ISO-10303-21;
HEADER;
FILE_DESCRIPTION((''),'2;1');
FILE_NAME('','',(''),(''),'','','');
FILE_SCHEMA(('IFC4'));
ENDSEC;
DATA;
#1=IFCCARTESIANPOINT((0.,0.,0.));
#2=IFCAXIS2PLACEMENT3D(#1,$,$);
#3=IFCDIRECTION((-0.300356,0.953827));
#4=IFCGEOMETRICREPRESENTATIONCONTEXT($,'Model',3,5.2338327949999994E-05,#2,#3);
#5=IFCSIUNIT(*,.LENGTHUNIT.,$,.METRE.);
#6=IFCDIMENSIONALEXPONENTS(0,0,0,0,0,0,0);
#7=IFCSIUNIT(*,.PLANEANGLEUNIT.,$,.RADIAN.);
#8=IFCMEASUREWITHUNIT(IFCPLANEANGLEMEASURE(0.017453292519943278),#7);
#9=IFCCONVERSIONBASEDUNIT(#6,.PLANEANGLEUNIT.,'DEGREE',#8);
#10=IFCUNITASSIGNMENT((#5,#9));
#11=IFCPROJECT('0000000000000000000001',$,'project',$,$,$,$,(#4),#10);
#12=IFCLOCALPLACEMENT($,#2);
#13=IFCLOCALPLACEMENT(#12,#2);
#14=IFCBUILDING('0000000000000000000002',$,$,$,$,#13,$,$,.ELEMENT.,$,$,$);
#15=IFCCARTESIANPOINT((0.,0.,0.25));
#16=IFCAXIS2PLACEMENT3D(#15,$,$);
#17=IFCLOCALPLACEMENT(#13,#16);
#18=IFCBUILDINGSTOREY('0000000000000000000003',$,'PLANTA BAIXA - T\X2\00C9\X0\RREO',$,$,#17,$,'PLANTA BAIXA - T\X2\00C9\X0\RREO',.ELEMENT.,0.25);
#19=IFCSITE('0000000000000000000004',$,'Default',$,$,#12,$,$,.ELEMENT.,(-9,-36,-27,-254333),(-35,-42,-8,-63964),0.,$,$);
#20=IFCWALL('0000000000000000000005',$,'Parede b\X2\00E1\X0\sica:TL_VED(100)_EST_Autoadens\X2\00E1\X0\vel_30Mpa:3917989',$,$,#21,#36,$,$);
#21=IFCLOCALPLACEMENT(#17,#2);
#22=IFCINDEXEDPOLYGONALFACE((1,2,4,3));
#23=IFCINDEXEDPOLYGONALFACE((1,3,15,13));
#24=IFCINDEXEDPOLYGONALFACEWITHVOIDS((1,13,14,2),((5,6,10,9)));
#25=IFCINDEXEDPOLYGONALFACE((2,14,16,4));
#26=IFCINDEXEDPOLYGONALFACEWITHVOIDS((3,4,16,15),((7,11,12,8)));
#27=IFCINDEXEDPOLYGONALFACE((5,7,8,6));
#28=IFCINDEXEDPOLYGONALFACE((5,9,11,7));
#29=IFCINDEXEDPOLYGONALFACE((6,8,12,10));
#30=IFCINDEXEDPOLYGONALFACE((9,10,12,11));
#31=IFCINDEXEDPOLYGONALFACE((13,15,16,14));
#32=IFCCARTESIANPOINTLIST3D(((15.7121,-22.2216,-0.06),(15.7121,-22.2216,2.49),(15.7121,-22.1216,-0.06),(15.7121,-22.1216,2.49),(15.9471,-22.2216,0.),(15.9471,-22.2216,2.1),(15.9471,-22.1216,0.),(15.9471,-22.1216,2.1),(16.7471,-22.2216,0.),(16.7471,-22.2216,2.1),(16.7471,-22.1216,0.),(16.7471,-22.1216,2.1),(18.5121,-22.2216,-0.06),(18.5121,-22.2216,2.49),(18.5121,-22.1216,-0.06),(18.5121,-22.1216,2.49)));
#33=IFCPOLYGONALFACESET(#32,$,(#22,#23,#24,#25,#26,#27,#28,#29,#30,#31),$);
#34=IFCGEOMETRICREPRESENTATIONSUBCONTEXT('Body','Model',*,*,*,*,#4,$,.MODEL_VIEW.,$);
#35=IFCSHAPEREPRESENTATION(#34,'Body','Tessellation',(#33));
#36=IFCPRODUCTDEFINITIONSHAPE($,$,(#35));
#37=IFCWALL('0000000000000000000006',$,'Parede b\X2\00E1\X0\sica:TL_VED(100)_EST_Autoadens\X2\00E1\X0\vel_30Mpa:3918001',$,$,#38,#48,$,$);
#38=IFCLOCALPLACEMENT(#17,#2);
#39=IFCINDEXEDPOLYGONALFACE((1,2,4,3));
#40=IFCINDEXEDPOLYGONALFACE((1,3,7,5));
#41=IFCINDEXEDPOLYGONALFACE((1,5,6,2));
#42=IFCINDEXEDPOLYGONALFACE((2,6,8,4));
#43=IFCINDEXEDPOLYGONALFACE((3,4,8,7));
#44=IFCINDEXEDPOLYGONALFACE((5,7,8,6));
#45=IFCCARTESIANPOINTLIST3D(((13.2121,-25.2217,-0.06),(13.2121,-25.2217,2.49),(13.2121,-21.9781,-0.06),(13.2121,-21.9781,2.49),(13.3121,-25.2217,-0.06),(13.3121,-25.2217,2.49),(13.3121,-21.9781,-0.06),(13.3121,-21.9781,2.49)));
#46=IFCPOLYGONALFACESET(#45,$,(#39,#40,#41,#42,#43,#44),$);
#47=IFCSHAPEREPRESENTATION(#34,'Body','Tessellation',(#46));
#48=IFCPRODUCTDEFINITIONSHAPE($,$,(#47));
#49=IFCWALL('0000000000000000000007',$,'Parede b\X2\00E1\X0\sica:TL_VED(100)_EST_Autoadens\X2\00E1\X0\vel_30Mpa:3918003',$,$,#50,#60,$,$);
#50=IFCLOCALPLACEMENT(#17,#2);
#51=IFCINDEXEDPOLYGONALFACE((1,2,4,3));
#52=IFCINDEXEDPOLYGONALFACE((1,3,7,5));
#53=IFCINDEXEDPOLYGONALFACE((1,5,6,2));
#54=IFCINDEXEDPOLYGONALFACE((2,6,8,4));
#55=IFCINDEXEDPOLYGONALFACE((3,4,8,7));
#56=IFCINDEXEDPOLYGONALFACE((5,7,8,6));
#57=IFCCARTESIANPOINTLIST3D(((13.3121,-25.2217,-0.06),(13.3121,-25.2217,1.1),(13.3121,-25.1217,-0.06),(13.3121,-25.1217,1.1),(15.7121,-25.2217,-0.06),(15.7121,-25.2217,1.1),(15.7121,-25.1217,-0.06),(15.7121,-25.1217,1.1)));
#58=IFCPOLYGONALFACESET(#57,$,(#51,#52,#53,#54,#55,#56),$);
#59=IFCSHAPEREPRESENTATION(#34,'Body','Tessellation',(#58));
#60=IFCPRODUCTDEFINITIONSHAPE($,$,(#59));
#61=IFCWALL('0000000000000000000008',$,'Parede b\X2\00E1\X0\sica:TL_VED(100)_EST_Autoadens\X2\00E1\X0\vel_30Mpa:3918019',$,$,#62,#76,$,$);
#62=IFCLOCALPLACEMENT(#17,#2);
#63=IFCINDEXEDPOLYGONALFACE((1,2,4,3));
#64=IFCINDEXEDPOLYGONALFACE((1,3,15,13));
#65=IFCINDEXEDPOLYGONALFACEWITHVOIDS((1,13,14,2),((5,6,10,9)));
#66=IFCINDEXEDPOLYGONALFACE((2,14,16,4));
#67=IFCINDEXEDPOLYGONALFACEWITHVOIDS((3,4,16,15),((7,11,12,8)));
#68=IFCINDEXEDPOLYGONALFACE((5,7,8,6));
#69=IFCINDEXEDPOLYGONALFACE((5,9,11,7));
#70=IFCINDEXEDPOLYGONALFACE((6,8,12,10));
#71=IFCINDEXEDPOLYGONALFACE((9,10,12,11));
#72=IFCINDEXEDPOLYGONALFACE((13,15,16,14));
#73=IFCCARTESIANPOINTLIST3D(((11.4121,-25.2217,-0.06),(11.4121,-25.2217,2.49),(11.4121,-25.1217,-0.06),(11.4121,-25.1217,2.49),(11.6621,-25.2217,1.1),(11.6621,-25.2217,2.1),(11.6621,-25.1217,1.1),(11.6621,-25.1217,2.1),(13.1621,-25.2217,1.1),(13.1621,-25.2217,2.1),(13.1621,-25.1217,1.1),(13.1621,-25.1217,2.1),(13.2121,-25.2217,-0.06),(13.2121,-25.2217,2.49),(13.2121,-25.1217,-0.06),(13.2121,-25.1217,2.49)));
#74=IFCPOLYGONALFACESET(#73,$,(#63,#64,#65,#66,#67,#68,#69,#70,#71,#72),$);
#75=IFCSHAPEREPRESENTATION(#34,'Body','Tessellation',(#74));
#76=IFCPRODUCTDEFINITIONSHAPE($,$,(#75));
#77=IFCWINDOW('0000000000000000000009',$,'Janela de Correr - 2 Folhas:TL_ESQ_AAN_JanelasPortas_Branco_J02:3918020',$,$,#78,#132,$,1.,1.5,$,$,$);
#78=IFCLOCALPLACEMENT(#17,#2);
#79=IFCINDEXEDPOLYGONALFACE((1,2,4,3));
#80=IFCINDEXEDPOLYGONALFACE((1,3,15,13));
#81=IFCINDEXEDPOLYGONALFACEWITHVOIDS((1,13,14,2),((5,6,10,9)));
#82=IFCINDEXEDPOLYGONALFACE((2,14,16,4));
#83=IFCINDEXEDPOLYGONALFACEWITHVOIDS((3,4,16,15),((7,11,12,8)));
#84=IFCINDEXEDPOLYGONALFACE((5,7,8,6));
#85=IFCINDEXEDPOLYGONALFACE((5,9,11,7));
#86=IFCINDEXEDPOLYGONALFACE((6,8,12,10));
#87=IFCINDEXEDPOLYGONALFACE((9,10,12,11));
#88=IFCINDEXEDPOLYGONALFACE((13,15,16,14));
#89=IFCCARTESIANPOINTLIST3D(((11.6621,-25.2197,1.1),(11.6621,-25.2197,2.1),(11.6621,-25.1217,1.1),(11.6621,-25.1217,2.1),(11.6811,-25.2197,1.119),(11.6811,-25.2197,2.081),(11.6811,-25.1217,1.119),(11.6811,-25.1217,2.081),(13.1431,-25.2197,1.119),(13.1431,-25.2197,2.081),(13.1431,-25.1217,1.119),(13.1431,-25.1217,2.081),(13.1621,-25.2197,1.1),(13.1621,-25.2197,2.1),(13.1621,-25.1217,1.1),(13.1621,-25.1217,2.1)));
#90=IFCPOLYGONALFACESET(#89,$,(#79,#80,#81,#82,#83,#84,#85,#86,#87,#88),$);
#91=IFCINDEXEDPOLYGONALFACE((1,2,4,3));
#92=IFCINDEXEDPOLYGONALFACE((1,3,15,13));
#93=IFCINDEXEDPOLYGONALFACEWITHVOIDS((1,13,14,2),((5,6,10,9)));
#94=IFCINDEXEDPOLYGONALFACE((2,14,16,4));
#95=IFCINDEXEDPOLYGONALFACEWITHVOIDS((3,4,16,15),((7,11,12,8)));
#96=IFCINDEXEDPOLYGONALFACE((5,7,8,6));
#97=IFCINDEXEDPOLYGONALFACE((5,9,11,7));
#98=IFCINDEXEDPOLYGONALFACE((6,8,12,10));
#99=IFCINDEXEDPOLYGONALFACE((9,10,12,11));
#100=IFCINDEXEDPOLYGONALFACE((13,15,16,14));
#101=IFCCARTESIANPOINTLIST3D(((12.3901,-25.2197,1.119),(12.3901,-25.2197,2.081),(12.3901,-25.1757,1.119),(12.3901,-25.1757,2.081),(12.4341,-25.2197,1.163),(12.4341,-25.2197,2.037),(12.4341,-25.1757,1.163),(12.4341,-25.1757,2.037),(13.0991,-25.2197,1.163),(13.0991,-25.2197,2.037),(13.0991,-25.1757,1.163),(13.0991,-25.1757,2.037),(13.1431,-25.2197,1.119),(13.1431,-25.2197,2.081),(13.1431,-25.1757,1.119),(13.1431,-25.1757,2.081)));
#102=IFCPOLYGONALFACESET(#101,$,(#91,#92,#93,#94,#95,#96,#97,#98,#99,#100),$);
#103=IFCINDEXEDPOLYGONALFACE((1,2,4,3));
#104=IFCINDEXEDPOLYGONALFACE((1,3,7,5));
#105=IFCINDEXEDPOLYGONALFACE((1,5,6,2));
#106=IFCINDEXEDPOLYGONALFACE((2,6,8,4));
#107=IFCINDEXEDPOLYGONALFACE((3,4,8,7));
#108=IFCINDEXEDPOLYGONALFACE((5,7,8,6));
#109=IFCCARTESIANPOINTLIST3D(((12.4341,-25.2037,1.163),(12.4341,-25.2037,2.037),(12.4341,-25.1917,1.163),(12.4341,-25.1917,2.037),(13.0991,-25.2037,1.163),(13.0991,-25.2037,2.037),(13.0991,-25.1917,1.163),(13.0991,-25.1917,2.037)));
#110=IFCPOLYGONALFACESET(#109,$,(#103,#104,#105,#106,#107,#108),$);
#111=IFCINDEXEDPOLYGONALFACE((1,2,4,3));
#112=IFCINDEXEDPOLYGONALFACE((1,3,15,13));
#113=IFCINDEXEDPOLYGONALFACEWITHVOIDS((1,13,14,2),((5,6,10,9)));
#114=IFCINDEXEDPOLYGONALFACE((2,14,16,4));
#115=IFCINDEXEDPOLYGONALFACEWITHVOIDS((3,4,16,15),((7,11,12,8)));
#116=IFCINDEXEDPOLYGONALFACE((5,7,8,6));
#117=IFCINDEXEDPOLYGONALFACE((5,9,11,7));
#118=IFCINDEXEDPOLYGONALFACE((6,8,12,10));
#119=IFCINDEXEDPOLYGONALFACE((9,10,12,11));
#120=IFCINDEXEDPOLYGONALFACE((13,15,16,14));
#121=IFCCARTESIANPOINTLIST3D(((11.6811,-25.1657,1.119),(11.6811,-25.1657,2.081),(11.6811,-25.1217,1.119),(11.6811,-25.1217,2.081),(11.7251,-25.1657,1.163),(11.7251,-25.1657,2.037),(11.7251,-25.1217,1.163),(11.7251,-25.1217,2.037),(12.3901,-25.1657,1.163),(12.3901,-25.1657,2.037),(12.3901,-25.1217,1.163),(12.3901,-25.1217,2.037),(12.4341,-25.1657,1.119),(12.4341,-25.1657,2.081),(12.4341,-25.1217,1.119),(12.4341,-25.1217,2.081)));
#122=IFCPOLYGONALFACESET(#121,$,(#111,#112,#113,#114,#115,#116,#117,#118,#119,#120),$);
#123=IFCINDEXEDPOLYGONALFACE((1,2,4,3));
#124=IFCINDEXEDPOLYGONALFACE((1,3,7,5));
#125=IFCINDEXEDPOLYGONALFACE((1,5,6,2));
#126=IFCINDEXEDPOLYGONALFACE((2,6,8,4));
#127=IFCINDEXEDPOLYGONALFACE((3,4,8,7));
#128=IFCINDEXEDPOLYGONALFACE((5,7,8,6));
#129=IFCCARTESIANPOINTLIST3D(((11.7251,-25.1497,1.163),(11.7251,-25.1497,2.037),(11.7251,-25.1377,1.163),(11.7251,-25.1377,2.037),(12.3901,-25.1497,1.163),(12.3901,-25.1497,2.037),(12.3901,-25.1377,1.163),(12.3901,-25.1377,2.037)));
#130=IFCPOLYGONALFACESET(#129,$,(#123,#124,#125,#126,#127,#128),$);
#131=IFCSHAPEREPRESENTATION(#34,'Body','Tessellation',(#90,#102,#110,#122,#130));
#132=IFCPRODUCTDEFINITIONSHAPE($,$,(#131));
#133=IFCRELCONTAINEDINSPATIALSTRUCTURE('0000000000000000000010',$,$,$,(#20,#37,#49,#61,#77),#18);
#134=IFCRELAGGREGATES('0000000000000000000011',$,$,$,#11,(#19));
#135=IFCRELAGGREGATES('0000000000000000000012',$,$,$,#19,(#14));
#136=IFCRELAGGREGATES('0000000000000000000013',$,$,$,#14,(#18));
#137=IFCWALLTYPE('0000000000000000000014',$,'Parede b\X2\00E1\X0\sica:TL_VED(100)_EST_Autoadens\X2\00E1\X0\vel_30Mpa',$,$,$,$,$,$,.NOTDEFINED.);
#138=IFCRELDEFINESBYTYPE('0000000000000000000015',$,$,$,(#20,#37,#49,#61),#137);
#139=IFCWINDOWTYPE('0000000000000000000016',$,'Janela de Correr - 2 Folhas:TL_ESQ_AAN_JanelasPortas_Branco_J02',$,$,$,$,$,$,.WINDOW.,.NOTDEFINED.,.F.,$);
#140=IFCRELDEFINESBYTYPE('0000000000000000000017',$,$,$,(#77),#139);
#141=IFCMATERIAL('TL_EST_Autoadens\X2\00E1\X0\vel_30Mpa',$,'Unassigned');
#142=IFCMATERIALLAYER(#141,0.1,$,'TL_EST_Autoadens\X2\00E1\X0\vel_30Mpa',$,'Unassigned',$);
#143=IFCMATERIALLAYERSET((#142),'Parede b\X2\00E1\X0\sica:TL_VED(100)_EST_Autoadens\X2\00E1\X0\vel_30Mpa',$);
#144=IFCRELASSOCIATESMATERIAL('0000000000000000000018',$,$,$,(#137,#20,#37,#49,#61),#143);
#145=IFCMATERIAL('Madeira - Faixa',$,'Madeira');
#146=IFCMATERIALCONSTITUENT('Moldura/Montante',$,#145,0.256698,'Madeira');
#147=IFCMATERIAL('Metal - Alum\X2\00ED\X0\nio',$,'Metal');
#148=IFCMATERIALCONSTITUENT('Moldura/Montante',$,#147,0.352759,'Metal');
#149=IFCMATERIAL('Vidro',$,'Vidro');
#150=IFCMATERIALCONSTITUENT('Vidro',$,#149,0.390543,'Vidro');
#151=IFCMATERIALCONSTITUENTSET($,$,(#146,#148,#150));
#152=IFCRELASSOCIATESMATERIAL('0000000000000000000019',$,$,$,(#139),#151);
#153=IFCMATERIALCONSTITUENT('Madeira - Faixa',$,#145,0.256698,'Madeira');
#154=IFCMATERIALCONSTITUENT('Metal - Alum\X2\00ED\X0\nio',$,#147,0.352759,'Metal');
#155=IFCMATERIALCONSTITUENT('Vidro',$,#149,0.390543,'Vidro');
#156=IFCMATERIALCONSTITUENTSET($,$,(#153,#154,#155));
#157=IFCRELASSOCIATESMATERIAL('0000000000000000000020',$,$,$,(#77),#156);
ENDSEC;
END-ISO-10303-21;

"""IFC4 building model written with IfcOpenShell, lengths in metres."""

from ifc_helpers import new_model, entity, si_unit, converted_unit, direction, frame, frame_2d, origin, origin_2d_with_axis, place, context, subcontext, project, spatial, polyline, rectangle, outline, extrude, source, transform, mapped, material, layer, layer_set, layer_usage, constituent, constituent_set, type_object, type_shapes, element, fill, save


model = new_model("IFC4")

# Units and contexts
model_context = context("Model", 3, precision=5.2338327949999994e-05, world=origin(), true_north=direction((-0.300356, 0.953827)))
body_context = subcontext(model_context, "Body", "Model", "MODEL_VIEW")
ifc_project = project(units=[si_unit("LENGTHUNIT", "METRE"), converted_unit("PLANEANGLEUNIT", "DEGREE", entity("IfcPlaneAngleMeasure", 0.017453292519943278), si_unit("PLANEANGLEUNIT", "RADIAN"), dimensions=[0, 0, 0, 0, 0, 0, 0])], contexts=[model_context])

# Site, building, storey
site_placement = place(None, origin())
site = spatial("IfcSite", under=ifc_project, at=site_placement, Name="Default", CompositionType="ELEMENT", RefLatitude=(-9, -36, -27, -254333), RefLongitude=(-35, -42, -8, -63964), RefElevation=0.0)
building_placement = place(site_placement, origin())
building = spatial("IfcBuilding", under=site, at=building_placement, CompositionType="ELEMENT")
storey_placement = place(building_placement, frame((0.0, 0.0, 0.25)))
storey = spatial("IfcBuildingStorey", under=building, at=storey_placement, Name="PLANTA BAIXA - TÉRREO", LongName="PLANTA BAIXA - TÉRREO", CompositionType="ELEMENT", Elevation=0.25)

# Wall, opening
ifc_material_1 = material(Name="TL_EST_Autoadensável_30Mpa", Category="Unassigned")
ifc_layer_1 = layer(ifc_material_1, 0.1, Name="TL_EST_Autoadensável_30Mpa", Category="Unassigned")
ifc_layer_set_1 = layer_set([ifc_layer_1], Name="Parede básica:TL_VED(100)_EST_Autoadensável_30Mpa")
ifc_layer_usage_1 = layer_usage(ifc_layer_set_1, "AXIS2", "POSITIVE", -0.05)
wall_type_1 = type_object("IfcWallType", Name="Parede básica:TL_VED(100)_EST_Autoadensável_30Mpa", PredefinedType="NOTDEFINED", material=ifc_layer_set_1)
wall_1_placement = place(storey_placement, frame((15.7121, -22.1716, -0.06)))
wall_1 = element("IfcWall", 1, at=wall_1_placement, inside=storey, type_object=wall_type_1, material=ifc_layer_usage_1, Name="Parede básica:TL_VED(100)_EST_Autoadensável_30Mpa:3917989", context=body_context, shape_type="SweptSolid", body=[
    extrude(rectangle(XDim=2.8, YDim=0.1, at=frame_2d((1.4, 0.0), x_axis=(-1.0, 0.0))), origin(), (0.0, 0.0, 1.0), 2.55),
])
opening_1_placement = place(wall_1_placement, frame((1.035, 0.05, 0.06)))
element("IfcOpeningElement", 2, at=opening_1_placement, cuts=wall_1, PredefinedType="OPENING", context=body_context, shape_type="SweptSolid", body=[
    extrude(rectangle(XDim=2.1, YDim=0.8, at=frame_2d((1.05, 0.4), x_axis=(1.0, 0.0))), frame((0.0, 0.0, 0.0), z_axis=(0.0, -1.0, 0.0), x_axis=(0.0, 0.0, 1.0)), (0.0, 0.0, 1.0), 0.1),
])

# Walls
ifc_layer_usage_2 = layer_usage(ifc_layer_set_1, "AXIS2", "NEGATIVE", 0.05)
wall_2_placement = place(storey_placement, frame((13.2621, -25.2217, -0.06), z_axis=(0.0, 0.0, 1.0), x_axis=(0.0, 1.0, 0.0)))
element("IfcWall", 3, at=wall_2_placement, inside=storey, type_object=wall_type_1, material=ifc_layer_usage_2, Name="Parede básica:TL_VED(100)_EST_Autoadensável_30Mpa:3918001", context=body_context, shape_type="SweptSolid", body=[
    extrude(rectangle(XDim=3.2437, YDim=0.1, at=frame_2d((1.6218, 0.0), x_axis=(-1.0, 0.0))), origin(), (0.0, 0.0, 1.0), 2.55),
])
ifc_layer_usage_3 = layer_usage(ifc_layer_set_1, "AXIS2", "NEGATIVE", 0.05)
wall_3_placement = place(storey_placement, frame((15.7121, -25.1717, -0.06), z_axis=(0.0, 0.0, 1.0), x_axis=(-1.0, 0.0, 0.0)))
element("IfcWall", 4, at=wall_3_placement, inside=storey, type_object=wall_type_1, material=ifc_layer_usage_3, Name="Parede básica:TL_VED(100)_EST_Autoadensável_30Mpa:3918003", context=body_context, shape_type="SweptSolid", body=[
    extrude(rectangle(XDim=2.4, YDim=0.1, at=frame_2d((1.2, 0.0), x_axis=(-1.0, 0.0))), origin(), (0.0, 0.0, 1.0), 1.16),
])

# Wall, opening, window
ifc_layer_usage_4 = layer_usage(ifc_layer_set_1, "AXIS2", "NEGATIVE", 0.05)
wall_4_placement = place(storey_placement, frame((13.2121, -25.1717, -0.06), z_axis=(0.0, 0.0, 1.0), x_axis=(-1.0, 0.0, 0.0)))
wall_4 = element("IfcWall", 5, at=wall_4_placement, inside=storey, type_object=wall_type_1, material=ifc_layer_usage_4, Name="Parede básica:TL_VED(100)_EST_Autoadensável_30Mpa:3918019", context=body_context, shape_type="SweptSolid", body=[
    extrude(rectangle(XDim=1.8, YDim=0.1, at=frame_2d((0.9, 0.0), x_axis=(-1.0, 0.0))), origin(), (0.0, 0.0, 1.0), 2.55),
])
opening_2_placement = place(wall_4_placement, frame((0.05, -0.05, 1.16)))
opening_2 = element("IfcOpeningElement", 6, at=opening_2_placement, cuts=wall_4, PredefinedType="OPENING", context=body_context, shape_type="SweptSolid", body=[
    extrude(rectangle(XDim=1.0, YDim=1.5, at=frame_2d((0.5, 0.75), x_axis=(-1.0, 0.0))), frame((0.0, 0.0, 0.0), z_axis=(0.0, 1.0, 0.0), x_axis=(0.0, 0.0, 1.0)), (0.0, 0.0, 1.0), 0.1),
])
ifc_material_2 = material(Name="Madeira - Faixa", Category="Madeira")
ifc_constituent_1 = constituent(ifc_material_2, Name="Madeira - Faixa", Category="Madeira", fraction=0.256698)
ifc_material_3 = material(Name="Metal - Alumínio", Category="Metal")
ifc_constituent_2 = constituent(ifc_material_3, Name="Metal - Alumínio", Category="Metal", fraction=0.352759)
ifc_material_4 = material(Name="Vidro", Category="Vidro")
ifc_constituent_3 = constituent(ifc_material_4, Name="Vidro", Category="Vidro", fraction=0.390543)
ifc_constituent_set_1 = constituent_set(constituents=[ifc_constituent_1, ifc_constituent_2, ifc_constituent_3])
ifc_constituent_4 = constituent(ifc_material_2, Name="Moldura/Montante", Category="Madeira", fraction=0.256698)
ifc_constituent_5 = constituent(ifc_material_3, Name="Moldura/Montante", Category="Metal", fraction=0.352759)
ifc_constituent_6 = constituent(ifc_material_4, Name="Vidro", Category="Vidro", fraction=0.390543)
ifc_constituent_set_2 = constituent_set(constituents=[ifc_constituent_4, ifc_constituent_5, ifc_constituent_6])
window_type = type_object("IfcWindowType", Name="Janela de Correr - 2 Folhas:TL_ESQ_AAN_JanelasPortas_Branco_J02", ParameterTakesPrecedence=False, PartitioningType="NOTDEFINED", PredefinedType="WINDOW", material=ifc_constituent_set_2)
shared_shape_1 = source(origin(), body_context, "Body", "SweptSolid", [
    extrude(outline(polyline([(-0.75, -0.5), (0.75, -0.5), (0.75, 0.5), (-0.75, 0.5), (-0.75, -0.5)]), holes=[polyline([(-0.731, -0.481), (-0.731, 0.481), (0.731, 0.481), (0.731, -0.481), (-0.731, -0.481)])]), frame((0.75, 0.124, 0.5), z_axis=(0.0, -1.0, 0.0), x_axis=(-1.0, 0.0, 0.0)), (0.0, 0.0, 1.0), 0.098),
    extrude(outline(polyline([(-0.3765, -0.481), (0.3765, -0.481), (0.3765, 0.481), (-0.3765, 0.481), (-0.3765, -0.481)]), holes=[polyline([(-0.3325, -0.437), (-0.3325, 0.437), (0.3325, 0.437), (0.3325, -0.437), (-0.3325, -0.437)])]), frame((0.3955, 0.124, 0.5), z_axis=(0.0, -1.0, 0.0), x_axis=(-1.0, 0.0, 0.0)), (0.0, 0.0, 1.0), 0.044),
    extrude(rectangle(XDim=0.665, YDim=0.012, at=origin_2d_with_axis()), frame((0.3955, 0.102, 0.063), z_axis=(0.0, 0.0, 1.0), x_axis=(-1.0, 0.0, 0.0)), (0.0, 0.0, 1.0), 0.874),
    extrude(outline(polyline([(-0.481, -0.3765), (0.481, -0.3765), (0.481, 0.3765), (-0.481, 0.3765), (-0.481, -0.3765)]), holes=[polyline([(-0.437, -0.3325), (-0.437, 0.3325), (0.437, 0.3325), (0.437, -0.3325), (-0.437, -0.3325)])]), frame((1.1045, 0.07, 0.5), z_axis=(0.0, -1.0, 0.0), x_axis=(0.0, 0.0, -1.0)), (0.0, 0.0, 1.0), 0.044),
    extrude(rectangle(XDim=0.665, YDim=0.012, at=origin_2d_with_axis()), frame((1.1045, 0.048, 0.063), z_axis=(0.0, 0.0, 1.0), x_axis=(-1.0, 0.0, 0.0)), (0.0, 0.0, 1.0), 0.874),
])
type_shapes(window_type, [shared_shape_1])
window_placement = place(opening_2_placement, frame((0.0, -0.026, 0.0)))
window = element("IfcWindow", 7, at=window_placement, inside=storey, type_object=window_type, material=ifc_constituent_set_1, Name="Janela de Correr - 2 Folhas:TL_ESQ_AAN_JanelasPortas_Branco_J02:3918020", OverallHeight=1.0, OverallWidth=1.5, context=body_context, shape_type="MappedRepresentation", body=[
    mapped(shared_shape_1, transform((0.0, 0.0, 0.0), scale=1.0)),
])
fill(opening_2, window)

save(model, "model.ifc")
